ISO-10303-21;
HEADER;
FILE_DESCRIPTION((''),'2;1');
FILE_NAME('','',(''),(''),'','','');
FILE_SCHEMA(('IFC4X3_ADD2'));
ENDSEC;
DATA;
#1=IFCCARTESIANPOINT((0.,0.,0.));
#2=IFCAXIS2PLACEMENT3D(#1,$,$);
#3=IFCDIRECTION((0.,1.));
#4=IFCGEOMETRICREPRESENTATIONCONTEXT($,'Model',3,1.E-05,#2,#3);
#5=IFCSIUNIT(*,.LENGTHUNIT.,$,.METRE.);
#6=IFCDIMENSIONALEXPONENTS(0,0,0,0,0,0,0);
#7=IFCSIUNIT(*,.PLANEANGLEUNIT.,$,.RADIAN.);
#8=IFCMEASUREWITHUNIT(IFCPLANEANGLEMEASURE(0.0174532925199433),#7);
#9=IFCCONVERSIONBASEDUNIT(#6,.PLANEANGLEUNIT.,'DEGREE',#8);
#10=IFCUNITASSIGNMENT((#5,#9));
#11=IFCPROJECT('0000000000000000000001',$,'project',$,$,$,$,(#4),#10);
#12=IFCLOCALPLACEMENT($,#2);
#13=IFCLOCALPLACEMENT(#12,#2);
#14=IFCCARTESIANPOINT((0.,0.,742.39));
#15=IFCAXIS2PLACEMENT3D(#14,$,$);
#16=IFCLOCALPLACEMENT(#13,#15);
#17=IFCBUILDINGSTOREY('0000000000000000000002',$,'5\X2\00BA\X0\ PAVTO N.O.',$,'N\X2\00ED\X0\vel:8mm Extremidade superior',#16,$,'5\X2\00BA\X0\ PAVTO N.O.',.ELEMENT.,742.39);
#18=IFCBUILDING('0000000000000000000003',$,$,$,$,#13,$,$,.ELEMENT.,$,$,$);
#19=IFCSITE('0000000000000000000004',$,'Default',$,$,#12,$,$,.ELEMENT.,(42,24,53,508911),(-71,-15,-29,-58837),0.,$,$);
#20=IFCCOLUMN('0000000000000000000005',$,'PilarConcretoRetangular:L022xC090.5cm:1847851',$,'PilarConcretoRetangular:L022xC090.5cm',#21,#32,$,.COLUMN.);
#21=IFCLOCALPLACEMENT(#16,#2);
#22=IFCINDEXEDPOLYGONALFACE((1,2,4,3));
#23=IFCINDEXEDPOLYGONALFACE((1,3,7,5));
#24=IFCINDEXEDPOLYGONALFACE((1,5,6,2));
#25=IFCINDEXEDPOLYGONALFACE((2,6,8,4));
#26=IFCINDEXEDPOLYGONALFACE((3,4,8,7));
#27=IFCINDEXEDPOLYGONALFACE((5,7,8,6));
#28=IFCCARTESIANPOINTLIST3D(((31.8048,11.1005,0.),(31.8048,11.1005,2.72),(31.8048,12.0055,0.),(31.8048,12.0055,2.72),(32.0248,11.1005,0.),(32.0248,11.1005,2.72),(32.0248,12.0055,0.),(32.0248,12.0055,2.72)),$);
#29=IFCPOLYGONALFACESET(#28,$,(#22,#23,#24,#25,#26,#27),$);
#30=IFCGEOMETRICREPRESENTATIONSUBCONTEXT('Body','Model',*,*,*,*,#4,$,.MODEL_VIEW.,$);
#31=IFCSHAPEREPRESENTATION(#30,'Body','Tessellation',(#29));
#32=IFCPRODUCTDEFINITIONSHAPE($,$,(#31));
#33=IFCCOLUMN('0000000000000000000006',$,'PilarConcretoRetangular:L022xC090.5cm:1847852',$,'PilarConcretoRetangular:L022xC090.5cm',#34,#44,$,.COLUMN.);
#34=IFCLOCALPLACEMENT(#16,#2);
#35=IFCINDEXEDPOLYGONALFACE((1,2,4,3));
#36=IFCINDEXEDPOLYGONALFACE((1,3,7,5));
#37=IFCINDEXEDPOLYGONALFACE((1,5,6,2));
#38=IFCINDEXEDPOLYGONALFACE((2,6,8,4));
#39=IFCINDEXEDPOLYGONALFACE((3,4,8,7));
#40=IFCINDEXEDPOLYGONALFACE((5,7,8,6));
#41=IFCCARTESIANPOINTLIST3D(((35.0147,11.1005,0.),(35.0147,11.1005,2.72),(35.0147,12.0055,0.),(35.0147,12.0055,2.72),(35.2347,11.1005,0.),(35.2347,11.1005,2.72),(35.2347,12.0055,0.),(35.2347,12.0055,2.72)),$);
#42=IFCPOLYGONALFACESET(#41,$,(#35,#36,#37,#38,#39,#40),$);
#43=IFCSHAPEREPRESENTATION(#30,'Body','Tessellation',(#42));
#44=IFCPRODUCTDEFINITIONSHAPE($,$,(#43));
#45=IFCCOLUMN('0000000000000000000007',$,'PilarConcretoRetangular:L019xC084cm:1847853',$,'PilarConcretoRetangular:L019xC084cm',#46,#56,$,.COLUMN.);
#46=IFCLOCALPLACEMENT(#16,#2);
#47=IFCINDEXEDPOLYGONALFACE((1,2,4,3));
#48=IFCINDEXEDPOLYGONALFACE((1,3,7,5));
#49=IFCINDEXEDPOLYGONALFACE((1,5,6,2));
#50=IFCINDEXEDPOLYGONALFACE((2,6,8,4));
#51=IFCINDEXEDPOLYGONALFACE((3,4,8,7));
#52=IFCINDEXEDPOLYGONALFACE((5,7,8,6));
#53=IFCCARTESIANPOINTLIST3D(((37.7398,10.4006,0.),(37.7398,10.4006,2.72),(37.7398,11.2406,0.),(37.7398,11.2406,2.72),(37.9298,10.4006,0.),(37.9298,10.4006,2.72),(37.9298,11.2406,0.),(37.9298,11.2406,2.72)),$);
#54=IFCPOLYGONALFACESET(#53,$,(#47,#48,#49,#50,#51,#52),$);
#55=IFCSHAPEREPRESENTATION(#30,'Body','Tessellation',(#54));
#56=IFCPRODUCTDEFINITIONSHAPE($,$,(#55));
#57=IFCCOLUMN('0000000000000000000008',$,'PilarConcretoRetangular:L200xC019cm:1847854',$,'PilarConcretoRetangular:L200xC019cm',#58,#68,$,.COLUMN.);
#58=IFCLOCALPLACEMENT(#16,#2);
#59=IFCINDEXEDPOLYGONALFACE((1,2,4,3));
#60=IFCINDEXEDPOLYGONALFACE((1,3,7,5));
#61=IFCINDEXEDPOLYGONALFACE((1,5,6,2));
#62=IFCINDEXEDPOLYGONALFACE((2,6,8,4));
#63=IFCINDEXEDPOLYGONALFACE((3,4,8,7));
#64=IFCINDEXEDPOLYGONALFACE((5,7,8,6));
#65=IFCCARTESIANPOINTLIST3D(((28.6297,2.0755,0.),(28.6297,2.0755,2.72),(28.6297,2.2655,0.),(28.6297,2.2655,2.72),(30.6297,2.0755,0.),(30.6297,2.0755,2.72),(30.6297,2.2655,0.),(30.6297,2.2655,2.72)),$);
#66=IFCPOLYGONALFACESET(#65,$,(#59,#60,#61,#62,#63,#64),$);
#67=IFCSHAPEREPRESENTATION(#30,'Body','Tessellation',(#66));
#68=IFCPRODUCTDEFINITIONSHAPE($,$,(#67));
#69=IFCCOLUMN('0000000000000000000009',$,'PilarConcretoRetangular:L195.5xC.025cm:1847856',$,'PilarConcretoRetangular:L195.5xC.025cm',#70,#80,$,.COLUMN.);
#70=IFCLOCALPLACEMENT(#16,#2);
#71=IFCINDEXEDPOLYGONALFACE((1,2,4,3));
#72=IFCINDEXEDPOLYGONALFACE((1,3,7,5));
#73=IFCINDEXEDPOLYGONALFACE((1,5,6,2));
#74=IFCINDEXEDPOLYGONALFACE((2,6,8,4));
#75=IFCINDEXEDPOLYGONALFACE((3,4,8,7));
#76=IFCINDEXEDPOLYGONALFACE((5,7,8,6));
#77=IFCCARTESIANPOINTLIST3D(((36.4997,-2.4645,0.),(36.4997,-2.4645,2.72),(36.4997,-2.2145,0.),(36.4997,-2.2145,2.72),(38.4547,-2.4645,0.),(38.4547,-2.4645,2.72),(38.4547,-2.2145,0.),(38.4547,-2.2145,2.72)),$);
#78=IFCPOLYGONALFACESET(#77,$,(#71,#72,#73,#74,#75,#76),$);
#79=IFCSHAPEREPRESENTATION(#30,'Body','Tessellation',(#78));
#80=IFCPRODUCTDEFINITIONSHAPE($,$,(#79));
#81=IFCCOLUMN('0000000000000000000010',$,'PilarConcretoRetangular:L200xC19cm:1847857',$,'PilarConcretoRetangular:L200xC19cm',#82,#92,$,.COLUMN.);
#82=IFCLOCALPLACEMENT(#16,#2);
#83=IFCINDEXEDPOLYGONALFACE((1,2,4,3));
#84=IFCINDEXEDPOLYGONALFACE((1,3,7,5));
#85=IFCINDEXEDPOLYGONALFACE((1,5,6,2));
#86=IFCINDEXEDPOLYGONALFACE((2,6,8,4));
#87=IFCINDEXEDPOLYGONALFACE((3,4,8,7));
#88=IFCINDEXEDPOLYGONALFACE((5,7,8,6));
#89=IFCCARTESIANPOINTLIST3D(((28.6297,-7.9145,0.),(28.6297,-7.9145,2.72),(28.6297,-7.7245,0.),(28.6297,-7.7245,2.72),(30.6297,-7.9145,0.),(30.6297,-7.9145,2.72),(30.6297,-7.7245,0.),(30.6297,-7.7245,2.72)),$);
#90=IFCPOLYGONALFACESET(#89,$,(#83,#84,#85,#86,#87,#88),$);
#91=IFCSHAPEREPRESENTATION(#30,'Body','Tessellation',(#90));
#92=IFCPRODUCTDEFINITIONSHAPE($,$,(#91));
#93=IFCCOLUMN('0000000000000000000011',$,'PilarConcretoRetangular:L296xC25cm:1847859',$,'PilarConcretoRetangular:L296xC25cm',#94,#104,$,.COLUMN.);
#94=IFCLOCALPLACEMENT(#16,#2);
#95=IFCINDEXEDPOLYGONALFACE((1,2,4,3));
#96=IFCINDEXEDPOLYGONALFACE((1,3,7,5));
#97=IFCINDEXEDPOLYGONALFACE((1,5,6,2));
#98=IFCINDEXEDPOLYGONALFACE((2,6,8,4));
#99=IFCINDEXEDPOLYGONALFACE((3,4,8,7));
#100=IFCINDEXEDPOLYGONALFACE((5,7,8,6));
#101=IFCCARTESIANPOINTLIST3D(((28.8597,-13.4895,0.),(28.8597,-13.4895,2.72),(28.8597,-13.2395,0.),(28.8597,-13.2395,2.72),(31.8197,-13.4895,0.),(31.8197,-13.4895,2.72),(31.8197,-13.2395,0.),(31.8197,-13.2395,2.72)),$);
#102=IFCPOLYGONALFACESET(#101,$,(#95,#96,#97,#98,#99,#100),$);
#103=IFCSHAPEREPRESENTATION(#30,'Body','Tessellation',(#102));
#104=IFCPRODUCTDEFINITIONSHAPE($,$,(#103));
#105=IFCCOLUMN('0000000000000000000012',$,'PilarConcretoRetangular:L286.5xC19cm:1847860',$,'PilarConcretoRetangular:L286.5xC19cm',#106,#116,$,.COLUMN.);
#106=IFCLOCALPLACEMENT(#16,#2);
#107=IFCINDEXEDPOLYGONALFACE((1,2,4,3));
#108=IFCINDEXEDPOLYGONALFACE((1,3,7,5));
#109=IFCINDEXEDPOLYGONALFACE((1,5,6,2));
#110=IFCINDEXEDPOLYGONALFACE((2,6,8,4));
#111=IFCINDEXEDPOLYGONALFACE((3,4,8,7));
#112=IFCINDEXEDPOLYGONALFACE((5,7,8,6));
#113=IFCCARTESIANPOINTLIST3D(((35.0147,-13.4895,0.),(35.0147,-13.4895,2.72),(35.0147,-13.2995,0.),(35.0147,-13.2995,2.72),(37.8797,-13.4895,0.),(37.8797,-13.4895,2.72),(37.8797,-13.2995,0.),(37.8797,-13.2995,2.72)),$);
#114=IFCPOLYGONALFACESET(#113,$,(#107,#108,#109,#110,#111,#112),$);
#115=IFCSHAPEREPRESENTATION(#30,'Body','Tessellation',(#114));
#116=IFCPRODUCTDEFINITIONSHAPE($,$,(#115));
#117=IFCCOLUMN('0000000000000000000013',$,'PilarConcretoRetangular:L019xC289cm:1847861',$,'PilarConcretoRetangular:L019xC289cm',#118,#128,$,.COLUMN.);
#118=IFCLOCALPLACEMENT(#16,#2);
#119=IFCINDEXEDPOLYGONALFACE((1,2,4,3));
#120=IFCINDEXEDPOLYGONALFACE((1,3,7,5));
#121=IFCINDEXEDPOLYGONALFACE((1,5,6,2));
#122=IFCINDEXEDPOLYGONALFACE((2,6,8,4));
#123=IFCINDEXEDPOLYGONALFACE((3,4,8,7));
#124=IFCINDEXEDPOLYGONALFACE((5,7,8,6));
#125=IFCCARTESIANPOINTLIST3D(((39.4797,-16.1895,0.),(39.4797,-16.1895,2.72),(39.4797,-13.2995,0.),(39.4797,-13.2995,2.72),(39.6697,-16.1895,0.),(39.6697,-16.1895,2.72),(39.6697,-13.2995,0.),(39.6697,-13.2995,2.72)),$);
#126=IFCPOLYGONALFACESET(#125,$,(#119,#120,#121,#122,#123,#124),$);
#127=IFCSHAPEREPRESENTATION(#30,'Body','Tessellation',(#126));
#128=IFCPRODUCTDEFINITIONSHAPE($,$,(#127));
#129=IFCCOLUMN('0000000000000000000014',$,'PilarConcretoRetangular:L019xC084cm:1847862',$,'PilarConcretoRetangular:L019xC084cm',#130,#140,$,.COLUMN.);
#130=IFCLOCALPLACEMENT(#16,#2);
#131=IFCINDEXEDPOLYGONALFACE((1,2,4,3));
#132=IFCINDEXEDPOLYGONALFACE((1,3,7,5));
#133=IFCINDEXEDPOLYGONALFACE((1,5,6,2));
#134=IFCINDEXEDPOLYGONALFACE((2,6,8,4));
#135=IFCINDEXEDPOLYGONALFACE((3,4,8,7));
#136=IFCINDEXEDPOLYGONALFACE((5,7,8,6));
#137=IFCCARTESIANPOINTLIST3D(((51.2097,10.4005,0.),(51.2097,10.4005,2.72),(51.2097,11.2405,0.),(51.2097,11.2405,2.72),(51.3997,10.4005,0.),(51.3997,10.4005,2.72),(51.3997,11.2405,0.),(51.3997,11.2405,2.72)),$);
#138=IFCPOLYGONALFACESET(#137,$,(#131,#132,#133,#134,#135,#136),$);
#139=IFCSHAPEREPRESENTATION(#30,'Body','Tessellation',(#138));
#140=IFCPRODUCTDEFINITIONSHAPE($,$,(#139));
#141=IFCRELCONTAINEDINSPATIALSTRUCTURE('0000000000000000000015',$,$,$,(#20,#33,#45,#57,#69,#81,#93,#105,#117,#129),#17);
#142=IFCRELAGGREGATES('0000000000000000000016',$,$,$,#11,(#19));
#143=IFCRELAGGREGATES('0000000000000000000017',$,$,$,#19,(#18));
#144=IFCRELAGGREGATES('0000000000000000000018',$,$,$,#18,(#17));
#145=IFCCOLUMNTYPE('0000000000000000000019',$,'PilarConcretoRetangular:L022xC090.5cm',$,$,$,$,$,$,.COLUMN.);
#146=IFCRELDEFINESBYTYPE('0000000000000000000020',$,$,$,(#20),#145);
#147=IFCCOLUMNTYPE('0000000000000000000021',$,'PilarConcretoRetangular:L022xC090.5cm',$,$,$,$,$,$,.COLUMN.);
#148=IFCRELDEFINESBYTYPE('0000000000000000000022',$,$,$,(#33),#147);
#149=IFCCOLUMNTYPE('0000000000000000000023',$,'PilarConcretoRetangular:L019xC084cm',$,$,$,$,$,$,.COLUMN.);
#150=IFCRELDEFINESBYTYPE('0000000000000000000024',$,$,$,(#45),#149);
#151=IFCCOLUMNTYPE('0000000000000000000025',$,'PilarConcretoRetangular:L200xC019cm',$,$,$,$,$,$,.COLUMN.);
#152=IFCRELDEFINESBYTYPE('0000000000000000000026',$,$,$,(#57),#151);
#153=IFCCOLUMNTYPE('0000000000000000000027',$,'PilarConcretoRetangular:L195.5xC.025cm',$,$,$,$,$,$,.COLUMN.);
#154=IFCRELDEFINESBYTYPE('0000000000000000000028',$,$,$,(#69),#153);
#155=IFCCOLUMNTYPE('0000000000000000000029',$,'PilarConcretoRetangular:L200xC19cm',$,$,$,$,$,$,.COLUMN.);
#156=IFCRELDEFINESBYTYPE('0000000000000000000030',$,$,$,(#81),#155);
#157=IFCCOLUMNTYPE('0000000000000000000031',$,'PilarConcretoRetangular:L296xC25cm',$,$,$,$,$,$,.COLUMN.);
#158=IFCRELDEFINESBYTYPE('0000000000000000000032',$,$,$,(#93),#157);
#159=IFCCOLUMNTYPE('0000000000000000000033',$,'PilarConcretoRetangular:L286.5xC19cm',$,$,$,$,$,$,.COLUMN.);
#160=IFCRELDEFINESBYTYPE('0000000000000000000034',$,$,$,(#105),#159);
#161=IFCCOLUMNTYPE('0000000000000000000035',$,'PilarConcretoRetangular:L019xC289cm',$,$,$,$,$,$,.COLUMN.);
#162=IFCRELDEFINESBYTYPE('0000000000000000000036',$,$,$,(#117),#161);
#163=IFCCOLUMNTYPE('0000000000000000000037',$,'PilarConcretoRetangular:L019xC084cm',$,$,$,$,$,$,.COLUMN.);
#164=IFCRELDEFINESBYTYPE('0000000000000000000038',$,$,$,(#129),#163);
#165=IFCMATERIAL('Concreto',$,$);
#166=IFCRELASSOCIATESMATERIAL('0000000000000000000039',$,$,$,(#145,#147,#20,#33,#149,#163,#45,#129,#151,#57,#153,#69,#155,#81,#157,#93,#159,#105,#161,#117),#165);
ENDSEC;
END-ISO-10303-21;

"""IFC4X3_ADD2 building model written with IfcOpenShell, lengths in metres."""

from ifc_helpers import new_model, entity, si_unit, converted_unit, direction, frame, frame_2d, origin, origin_2d_with_axis, place, context, subcontext, project, spatial, rectangle, extrude, source, transform, mapped, material, material_profile, profile_set, profile_usage, type_object, type_shapes, element, save


model = new_model("IFC4X3_ADD2")

# Units and contexts
model_context = context("Model", 3, precision=1e-05, world=origin(), true_north=direction((0.0, 1.0)))
body_context = subcontext(model_context, "Body", "Model", "MODEL_VIEW")
ifc_project = project(units=[si_unit("LENGTHUNIT", "METRE"), converted_unit("PLANEANGLEUNIT", "DEGREE", entity("IfcPlaneAngleMeasure", 0.0174532925199433), si_unit("PLANEANGLEUNIT", "RADIAN"), dimensions=[0, 0, 0, 0, 0, 0, 0])], contexts=[model_context])

# Site, building, storey
site_placement = place(None, origin())
site = spatial("IfcSite", under=ifc_project, at=site_placement, Name="Default", CompositionType="ELEMENT", RefLatitude=(42, 24, 53, 508911), RefLongitude=(-71, -15, -29, -58837), RefElevation=0.0)
building_placement = place(site_placement, origin())
building = spatial("IfcBuilding", under=site, at=building_placement, CompositionType="ELEMENT")
storey_placement = place(building_placement, frame((0.0, 0.0, 742.39)))
storey = spatial("IfcBuildingStorey", under=building, at=storey_placement, Name="5º PAVTO N.O.", ObjectType="Nível:8mm Extremidade superior", LongName="5º PAVTO N.O.", CompositionType="ELEMENT", Elevation=742.39)

# Columns
ifc_material = material(Name="Concreto")
ifc_material_profile_1 = material_profile(ifc_material, rectangle(XDim=0.22, YDim=0.905, at=frame_2d((0.0, 0.0), x_axis=(1.0, 0.0))), Name="L022xC090.5cm")
ifc_profile_set_1 = profile_set([ifc_material_profile_1], Name="L022xC090.5cm")
ifc_profile_usage_1 = profile_usage(ifc_profile_set_1)
column_type_1 = type_object("IfcColumnType", Name="PilarConcretoRetangular:L022xC090.5cm", PredefinedType="COLUMN", material=ifc_profile_set_1)
shared_shape_1 = source(origin(), body_context, "Body", "SweptSolid", [
    extrude(rectangle(XDim=0.22, YDim=0.905, at=frame_2d((0.0, 0.0), x_axis=(1.0, 0.0))), frame((31.9148, 11.553, 742.39), z_axis=(0.0, 0.0, 1.0), x_axis=(-1.0, 0.0, 0.0)), (0.0, 0.0, 1.0), 2.72),
])
type_shapes(column_type_1, [shared_shape_1])
column_1_placement = place(storey_placement, frame((0.0, 0.0, -742.39)))
element("IfcColumn", 1, at=column_1_placement, inside=storey, type_object=column_type_1, material=ifc_profile_usage_1, Name="PilarConcretoRetangular:L022xC090.5cm:1847851", ObjectType="PilarConcretoRetangular:L022xC090.5cm", PredefinedType="COLUMN", context=body_context, shape_type="MappedRepresentation", body=[
    mapped(shared_shape_1, transform((0.0, 0.0, 0.0), scale=1.0)),
])
column_type_2 = type_object("IfcColumnType", Name="PilarConcretoRetangular:L022xC090.5cm", PredefinedType="COLUMN", material=ifc_profile_set_1)
shared_shape_2 = source(origin(), body_context, "Body", "SweptSolid", [
    extrude(rectangle(XDim=0.22, YDim=0.905, at=frame_2d((0.0, 0.0), x_axis=(1.0, 0.0))), frame((35.1247, 11.553, 742.39), z_axis=(0.0, 0.0, 1.0), x_axis=(-1.0, 0.0, 0.0)), (0.0, 0.0, 1.0), 2.72),
])
type_shapes(column_type_2, [shared_shape_2])
column_2_placement = place(storey_placement, frame((0.0, 0.0, -742.39)))
element("IfcColumn", 2, at=column_2_placement, inside=storey, type_object=column_type_2, material=ifc_profile_usage_1, Name="PilarConcretoRetangular:L022xC090.5cm:1847852", ObjectType="PilarConcretoRetangular:L022xC090.5cm", PredefinedType="COLUMN", context=body_context, shape_type="MappedRepresentation", body=[
    mapped(shared_shape_2, transform((0.0, 0.0, 0.0), scale=1.0)),
])
ifc_material_profile_2 = material_profile(ifc_material, rectangle(XDim=0.19, YDim=0.84, at=frame_2d((0.0, 0.0), x_axis=(1.0, 0.0))), Name="L019xC084cm")
ifc_profile_set_2 = profile_set([ifc_material_profile_2], Name="L019xC084cm")
ifc_profile_usage_2 = profile_usage(ifc_profile_set_2)
column_type_3 = type_object("IfcColumnType", Name="PilarConcretoRetangular:L019xC084cm", PredefinedType="COLUMN", material=ifc_profile_set_2)
shared_shape_3 = source(origin(), body_context, "Body", "SweptSolid", [
    extrude(rectangle(XDim=0.19, YDim=0.84, at=origin_2d_with_axis()), frame((37.8348, 10.8206, 742.39), z_axis=(0.0, 0.0, 1.0), x_axis=(-1.0, 0.0, 0.0)), (0.0, 0.0, 1.0), 2.72),
])
type_shapes(column_type_3, [shared_shape_3])
column_3_placement = place(storey_placement, frame((0.0, 0.0, -742.39)))
element("IfcColumn", 3, at=column_3_placement, inside=storey, type_object=column_type_3, material=ifc_profile_usage_2, Name="PilarConcretoRetangular:L019xC084cm:1847853", ObjectType="PilarConcretoRetangular:L019xC084cm", PredefinedType="COLUMN", context=body_context, shape_type="MappedRepresentation", body=[
    mapped(shared_shape_3, transform((0.0, 0.0, 0.0), scale=1.0)),
])
ifc_material_profile_3 = material_profile(ifc_material, rectangle(XDim=2.0, YDim=0.19, at=frame_2d((0.0, 0.0), x_axis=(1.0, 0.0))), Name="L200xC019cm")
ifc_profile_set_3 = profile_set([ifc_material_profile_3], Name="L200xC019cm")
ifc_profile_usage_3 = profile_usage(ifc_profile_set_3)
column_type_4 = type_object("IfcColumnType", Name="PilarConcretoRetangular:L200xC019cm", PredefinedType="COLUMN", material=ifc_profile_set_3)
shared_shape_4 = source(origin(), body_context, "Body", "SweptSolid", [
    extrude(rectangle(XDim=2.0, YDim=0.19, at=frame_2d((0.0, 0.0), x_axis=(1.0, 0.0))), frame((29.6297, 2.1705, 742.39)), (0.0, 0.0, 1.0), 2.72),
])
type_shapes(column_type_4, [shared_shape_4])
column_4_placement = place(storey_placement, frame((0.0, 0.0, -742.39)))
element("IfcColumn", 4, at=column_4_placement, inside=storey, type_object=column_type_4, material=ifc_profile_usage_3, Name="PilarConcretoRetangular:L200xC019cm:1847854", ObjectType="PilarConcretoRetangular:L200xC019cm", PredefinedType="COLUMN", context=body_context, shape_type="MappedRepresentation", body=[
    mapped(shared_shape_4, transform((0.0, 0.0, 0.0), scale=1.0)),
])
ifc_material_profile_4 = material_profile(ifc_material, rectangle(XDim=1.955, YDim=0.25, at=frame_2d((0.0, 0.0), x_axis=(1.0, 0.0))), Name="L195.5xC.025cm")
ifc_profile_set_4 = profile_set([ifc_material_profile_4], Name="L195.5xC.025cm")
ifc_profile_usage_4 = profile_usage(ifc_profile_set_4)
column_type_5 = type_object("IfcColumnType", Name="PilarConcretoRetangular:L195.5xC.025cm", PredefinedType="COLUMN", material=ifc_profile_set_4)
shared_shape_5 = source(origin(), body_context, "Body", "SweptSolid", [
    extrude(rectangle(XDim=1.955, YDim=0.25, at=frame_2d((0.0, 0.0), x_axis=(1.0, 0.0))), frame((37.4772, -2.3395, 742.39)), (0.0, 0.0, 1.0), 2.72),
])
type_shapes(column_type_5, [shared_shape_5])
column_5_placement = place(storey_placement, frame((0.0, 0.0, -742.39)))
element("IfcColumn", 5, at=column_5_placement, inside=storey, type_object=column_type_5, material=ifc_profile_usage_4, Name="PilarConcretoRetangular:L195.5xC.025cm:1847856", ObjectType="PilarConcretoRetangular:L195.5xC.025cm", PredefinedType="COLUMN", context=body_context, shape_type="MappedRepresentation", body=[
    mapped(shared_shape_5, transform((0.0, 0.0, 0.0), scale=1.0)),
])
ifc_material_profile_5 = material_profile(ifc_material, rectangle(XDim=2.0, YDim=0.19, at=frame_2d((0.0, 0.0), x_axis=(1.0, 0.0))), Name="L200xC19cm")
ifc_profile_set_5 = profile_set([ifc_material_profile_5], Name="L200xC19cm")
ifc_profile_usage_5 = profile_usage(ifc_profile_set_5)
column_type_6 = type_object("IfcColumnType", Name="PilarConcretoRetangular:L200xC19cm", PredefinedType="COLUMN", material=ifc_profile_set_5)
shared_shape_6 = source(origin(), body_context, "Body", "SweptSolid", [
    extrude(rectangle(XDim=2.0, YDim=0.19, at=frame_2d((0.0, 0.0), x_axis=(1.0, 0.0))), frame((29.6297, -7.8195, 742.39)), (0.0, 0.0, 1.0), 2.72),
])
type_shapes(column_type_6, [shared_shape_6])
column_6_placement = place(storey_placement, frame((0.0, 0.0, -742.39)))
element("IfcColumn", 6, at=column_6_placement, inside=storey, type_object=column_type_6, material=ifc_profile_usage_5, Name="PilarConcretoRetangular:L200xC19cm:1847857", ObjectType="PilarConcretoRetangular:L200xC19cm", PredefinedType="COLUMN", context=body_context, shape_type="MappedRepresentation", body=[
    mapped(shared_shape_6, transform((0.0, 0.0, 0.0), scale=1.0)),
])
ifc_material_profile_6 = material_profile(ifc_material, rectangle(XDim=2.96, YDim=0.25, at=frame_2d((0.0, 0.0), x_axis=(1.0, 0.0))), Name="L296xC25cm")
ifc_profile_set_6 = profile_set([ifc_material_profile_6], Name="L296xC25cm")
ifc_profile_usage_6 = profile_usage(ifc_profile_set_6)
column_type_7 = type_object("IfcColumnType", Name="PilarConcretoRetangular:L296xC25cm", PredefinedType="COLUMN", material=ifc_profile_set_6)
shared_shape_7 = source(origin(), body_context, "Body", "SweptSolid", [
    extrude(rectangle(XDim=2.96, YDim=0.25, at=frame_2d((0.0, 0.0), x_axis=(1.0, 0.0))), frame((30.3397, -13.3645, 742.39)), (0.0, 0.0, 1.0), 2.72),
])
type_shapes(column_type_7, [shared_shape_7])
column_7_placement = place(storey_placement, frame((0.0, 0.0, -742.39)))
element("IfcColumn", 7, at=column_7_placement, inside=storey, type_object=column_type_7, material=ifc_profile_usage_6, Name="PilarConcretoRetangular:L296xC25cm:1847859", ObjectType="PilarConcretoRetangular:L296xC25cm", PredefinedType="COLUMN", context=body_context, shape_type="MappedRepresentation", body=[
    mapped(shared_shape_7, transform((0.0, 0.0, 0.0), scale=1.0)),
])
ifc_material_profile_7 = material_profile(ifc_material, rectangle(XDim=2.865, YDim=0.19, at=frame_2d((0.0, 0.0), x_axis=(1.0, 0.0))), Name="L286.5xC19cm")
ifc_profile_set_7 = profile_set([ifc_material_profile_7], Name="L286.5xC19cm")
ifc_profile_usage_7 = profile_usage(ifc_profile_set_7)
column_type_8 = type_object("IfcColumnType", Name="PilarConcretoRetangular:L286.5xC19cm", PredefinedType="COLUMN", material=ifc_profile_set_7)
shared_shape_8 = source(origin(), body_context, "Body", "SweptSolid", [
    extrude(rectangle(XDim=2.865, YDim=0.19, at=frame_2d((0.0, 0.0), x_axis=(1.0, 0.0))), frame((36.4472, -13.3945, 742.39)), (0.0, 0.0, 1.0), 2.72),
])
type_shapes(column_type_8, [shared_shape_8])
column_8_placement = place(storey_placement, frame((0.0, 0.0, -742.39)))
element("IfcColumn", 8, at=column_8_placement, inside=storey, type_object=column_type_8, material=ifc_profile_usage_7, Name="PilarConcretoRetangular:L286.5xC19cm:1847860", ObjectType="PilarConcretoRetangular:L286.5xC19cm", PredefinedType="COLUMN", context=body_context, shape_type="MappedRepresentation", body=[
    mapped(shared_shape_8, transform((0.0, 0.0, 0.0), scale=1.0)),
])
ifc_material_profile_8 = material_profile(ifc_material, rectangle(XDim=0.19, YDim=2.89, at=frame_2d((0.0, 0.0), x_axis=(1.0, 0.0))), Name="L019xC289cm")
ifc_profile_set_8 = profile_set([ifc_material_profile_8], Name="L019xC289cm")
ifc_profile_usage_8 = profile_usage(ifc_profile_set_8)
column_type_9 = type_object("IfcColumnType", Name="PilarConcretoRetangular:L019xC289cm", PredefinedType="COLUMN", material=ifc_profile_set_8)
shared_shape_9 = source(origin(), body_context, "Body", "SweptSolid", [
    extrude(rectangle(XDim=0.19, YDim=2.89, at=frame_2d((0.0, 0.0), x_axis=(1.0, 0.0))), frame((39.5747, -14.7445, 742.39), z_axis=(0.0, 0.0, 1.0), x_axis=(-1.0, 0.0, 0.0)), (0.0, 0.0, 1.0), 2.72),
])
type_shapes(column_type_9, [shared_shape_9])
column_9_placement = place(storey_placement, frame((0.0, 0.0, -742.39)))
element("IfcColumn", 9, at=column_9_placement, inside=storey, type_object=column_type_9, material=ifc_profile_usage_8, Name="PilarConcretoRetangular:L019xC289cm:1847861", ObjectType="PilarConcretoRetangular:L019xC289cm", PredefinedType="COLUMN", context=body_context, shape_type="MappedRepresentation", body=[
    mapped(shared_shape_9, transform((0.0, 0.0, 0.0), scale=1.0)),
])
column_type_10 = type_object("IfcColumnType", Name="PilarConcretoRetangular:L019xC084cm", PredefinedType="COLUMN", material=ifc_profile_set_2)
shared_shape_10 = source(origin(), body_context, "Body", "SweptSolid", [
    extrude(rectangle(XDim=0.19, YDim=0.84, at=frame_2d((0.0, 0.0), x_axis=(1.0, 0.0))), frame((51.3047, 10.8205, 742.39)), (0.0, 0.0, 1.0), 2.72),
])
type_shapes(column_type_10, [shared_shape_10])
column_10_placement = place(storey_placement, frame((0.0, 0.0, -742.39)))
element("IfcColumn", 10, at=column_10_placement, inside=storey, type_object=column_type_10, material=ifc_profile_usage_2, Name="PilarConcretoRetangular:L019xC084cm:1847862", ObjectType="PilarConcretoRetangular:L019xC084cm", PredefinedType="COLUMN", context=body_context, shape_type="MappedRepresentation", body=[
    mapped(shared_shape_10, transform((0.0, 0.0, 0.0), scale=1.0)),
])

save(model, "model.ifc")
